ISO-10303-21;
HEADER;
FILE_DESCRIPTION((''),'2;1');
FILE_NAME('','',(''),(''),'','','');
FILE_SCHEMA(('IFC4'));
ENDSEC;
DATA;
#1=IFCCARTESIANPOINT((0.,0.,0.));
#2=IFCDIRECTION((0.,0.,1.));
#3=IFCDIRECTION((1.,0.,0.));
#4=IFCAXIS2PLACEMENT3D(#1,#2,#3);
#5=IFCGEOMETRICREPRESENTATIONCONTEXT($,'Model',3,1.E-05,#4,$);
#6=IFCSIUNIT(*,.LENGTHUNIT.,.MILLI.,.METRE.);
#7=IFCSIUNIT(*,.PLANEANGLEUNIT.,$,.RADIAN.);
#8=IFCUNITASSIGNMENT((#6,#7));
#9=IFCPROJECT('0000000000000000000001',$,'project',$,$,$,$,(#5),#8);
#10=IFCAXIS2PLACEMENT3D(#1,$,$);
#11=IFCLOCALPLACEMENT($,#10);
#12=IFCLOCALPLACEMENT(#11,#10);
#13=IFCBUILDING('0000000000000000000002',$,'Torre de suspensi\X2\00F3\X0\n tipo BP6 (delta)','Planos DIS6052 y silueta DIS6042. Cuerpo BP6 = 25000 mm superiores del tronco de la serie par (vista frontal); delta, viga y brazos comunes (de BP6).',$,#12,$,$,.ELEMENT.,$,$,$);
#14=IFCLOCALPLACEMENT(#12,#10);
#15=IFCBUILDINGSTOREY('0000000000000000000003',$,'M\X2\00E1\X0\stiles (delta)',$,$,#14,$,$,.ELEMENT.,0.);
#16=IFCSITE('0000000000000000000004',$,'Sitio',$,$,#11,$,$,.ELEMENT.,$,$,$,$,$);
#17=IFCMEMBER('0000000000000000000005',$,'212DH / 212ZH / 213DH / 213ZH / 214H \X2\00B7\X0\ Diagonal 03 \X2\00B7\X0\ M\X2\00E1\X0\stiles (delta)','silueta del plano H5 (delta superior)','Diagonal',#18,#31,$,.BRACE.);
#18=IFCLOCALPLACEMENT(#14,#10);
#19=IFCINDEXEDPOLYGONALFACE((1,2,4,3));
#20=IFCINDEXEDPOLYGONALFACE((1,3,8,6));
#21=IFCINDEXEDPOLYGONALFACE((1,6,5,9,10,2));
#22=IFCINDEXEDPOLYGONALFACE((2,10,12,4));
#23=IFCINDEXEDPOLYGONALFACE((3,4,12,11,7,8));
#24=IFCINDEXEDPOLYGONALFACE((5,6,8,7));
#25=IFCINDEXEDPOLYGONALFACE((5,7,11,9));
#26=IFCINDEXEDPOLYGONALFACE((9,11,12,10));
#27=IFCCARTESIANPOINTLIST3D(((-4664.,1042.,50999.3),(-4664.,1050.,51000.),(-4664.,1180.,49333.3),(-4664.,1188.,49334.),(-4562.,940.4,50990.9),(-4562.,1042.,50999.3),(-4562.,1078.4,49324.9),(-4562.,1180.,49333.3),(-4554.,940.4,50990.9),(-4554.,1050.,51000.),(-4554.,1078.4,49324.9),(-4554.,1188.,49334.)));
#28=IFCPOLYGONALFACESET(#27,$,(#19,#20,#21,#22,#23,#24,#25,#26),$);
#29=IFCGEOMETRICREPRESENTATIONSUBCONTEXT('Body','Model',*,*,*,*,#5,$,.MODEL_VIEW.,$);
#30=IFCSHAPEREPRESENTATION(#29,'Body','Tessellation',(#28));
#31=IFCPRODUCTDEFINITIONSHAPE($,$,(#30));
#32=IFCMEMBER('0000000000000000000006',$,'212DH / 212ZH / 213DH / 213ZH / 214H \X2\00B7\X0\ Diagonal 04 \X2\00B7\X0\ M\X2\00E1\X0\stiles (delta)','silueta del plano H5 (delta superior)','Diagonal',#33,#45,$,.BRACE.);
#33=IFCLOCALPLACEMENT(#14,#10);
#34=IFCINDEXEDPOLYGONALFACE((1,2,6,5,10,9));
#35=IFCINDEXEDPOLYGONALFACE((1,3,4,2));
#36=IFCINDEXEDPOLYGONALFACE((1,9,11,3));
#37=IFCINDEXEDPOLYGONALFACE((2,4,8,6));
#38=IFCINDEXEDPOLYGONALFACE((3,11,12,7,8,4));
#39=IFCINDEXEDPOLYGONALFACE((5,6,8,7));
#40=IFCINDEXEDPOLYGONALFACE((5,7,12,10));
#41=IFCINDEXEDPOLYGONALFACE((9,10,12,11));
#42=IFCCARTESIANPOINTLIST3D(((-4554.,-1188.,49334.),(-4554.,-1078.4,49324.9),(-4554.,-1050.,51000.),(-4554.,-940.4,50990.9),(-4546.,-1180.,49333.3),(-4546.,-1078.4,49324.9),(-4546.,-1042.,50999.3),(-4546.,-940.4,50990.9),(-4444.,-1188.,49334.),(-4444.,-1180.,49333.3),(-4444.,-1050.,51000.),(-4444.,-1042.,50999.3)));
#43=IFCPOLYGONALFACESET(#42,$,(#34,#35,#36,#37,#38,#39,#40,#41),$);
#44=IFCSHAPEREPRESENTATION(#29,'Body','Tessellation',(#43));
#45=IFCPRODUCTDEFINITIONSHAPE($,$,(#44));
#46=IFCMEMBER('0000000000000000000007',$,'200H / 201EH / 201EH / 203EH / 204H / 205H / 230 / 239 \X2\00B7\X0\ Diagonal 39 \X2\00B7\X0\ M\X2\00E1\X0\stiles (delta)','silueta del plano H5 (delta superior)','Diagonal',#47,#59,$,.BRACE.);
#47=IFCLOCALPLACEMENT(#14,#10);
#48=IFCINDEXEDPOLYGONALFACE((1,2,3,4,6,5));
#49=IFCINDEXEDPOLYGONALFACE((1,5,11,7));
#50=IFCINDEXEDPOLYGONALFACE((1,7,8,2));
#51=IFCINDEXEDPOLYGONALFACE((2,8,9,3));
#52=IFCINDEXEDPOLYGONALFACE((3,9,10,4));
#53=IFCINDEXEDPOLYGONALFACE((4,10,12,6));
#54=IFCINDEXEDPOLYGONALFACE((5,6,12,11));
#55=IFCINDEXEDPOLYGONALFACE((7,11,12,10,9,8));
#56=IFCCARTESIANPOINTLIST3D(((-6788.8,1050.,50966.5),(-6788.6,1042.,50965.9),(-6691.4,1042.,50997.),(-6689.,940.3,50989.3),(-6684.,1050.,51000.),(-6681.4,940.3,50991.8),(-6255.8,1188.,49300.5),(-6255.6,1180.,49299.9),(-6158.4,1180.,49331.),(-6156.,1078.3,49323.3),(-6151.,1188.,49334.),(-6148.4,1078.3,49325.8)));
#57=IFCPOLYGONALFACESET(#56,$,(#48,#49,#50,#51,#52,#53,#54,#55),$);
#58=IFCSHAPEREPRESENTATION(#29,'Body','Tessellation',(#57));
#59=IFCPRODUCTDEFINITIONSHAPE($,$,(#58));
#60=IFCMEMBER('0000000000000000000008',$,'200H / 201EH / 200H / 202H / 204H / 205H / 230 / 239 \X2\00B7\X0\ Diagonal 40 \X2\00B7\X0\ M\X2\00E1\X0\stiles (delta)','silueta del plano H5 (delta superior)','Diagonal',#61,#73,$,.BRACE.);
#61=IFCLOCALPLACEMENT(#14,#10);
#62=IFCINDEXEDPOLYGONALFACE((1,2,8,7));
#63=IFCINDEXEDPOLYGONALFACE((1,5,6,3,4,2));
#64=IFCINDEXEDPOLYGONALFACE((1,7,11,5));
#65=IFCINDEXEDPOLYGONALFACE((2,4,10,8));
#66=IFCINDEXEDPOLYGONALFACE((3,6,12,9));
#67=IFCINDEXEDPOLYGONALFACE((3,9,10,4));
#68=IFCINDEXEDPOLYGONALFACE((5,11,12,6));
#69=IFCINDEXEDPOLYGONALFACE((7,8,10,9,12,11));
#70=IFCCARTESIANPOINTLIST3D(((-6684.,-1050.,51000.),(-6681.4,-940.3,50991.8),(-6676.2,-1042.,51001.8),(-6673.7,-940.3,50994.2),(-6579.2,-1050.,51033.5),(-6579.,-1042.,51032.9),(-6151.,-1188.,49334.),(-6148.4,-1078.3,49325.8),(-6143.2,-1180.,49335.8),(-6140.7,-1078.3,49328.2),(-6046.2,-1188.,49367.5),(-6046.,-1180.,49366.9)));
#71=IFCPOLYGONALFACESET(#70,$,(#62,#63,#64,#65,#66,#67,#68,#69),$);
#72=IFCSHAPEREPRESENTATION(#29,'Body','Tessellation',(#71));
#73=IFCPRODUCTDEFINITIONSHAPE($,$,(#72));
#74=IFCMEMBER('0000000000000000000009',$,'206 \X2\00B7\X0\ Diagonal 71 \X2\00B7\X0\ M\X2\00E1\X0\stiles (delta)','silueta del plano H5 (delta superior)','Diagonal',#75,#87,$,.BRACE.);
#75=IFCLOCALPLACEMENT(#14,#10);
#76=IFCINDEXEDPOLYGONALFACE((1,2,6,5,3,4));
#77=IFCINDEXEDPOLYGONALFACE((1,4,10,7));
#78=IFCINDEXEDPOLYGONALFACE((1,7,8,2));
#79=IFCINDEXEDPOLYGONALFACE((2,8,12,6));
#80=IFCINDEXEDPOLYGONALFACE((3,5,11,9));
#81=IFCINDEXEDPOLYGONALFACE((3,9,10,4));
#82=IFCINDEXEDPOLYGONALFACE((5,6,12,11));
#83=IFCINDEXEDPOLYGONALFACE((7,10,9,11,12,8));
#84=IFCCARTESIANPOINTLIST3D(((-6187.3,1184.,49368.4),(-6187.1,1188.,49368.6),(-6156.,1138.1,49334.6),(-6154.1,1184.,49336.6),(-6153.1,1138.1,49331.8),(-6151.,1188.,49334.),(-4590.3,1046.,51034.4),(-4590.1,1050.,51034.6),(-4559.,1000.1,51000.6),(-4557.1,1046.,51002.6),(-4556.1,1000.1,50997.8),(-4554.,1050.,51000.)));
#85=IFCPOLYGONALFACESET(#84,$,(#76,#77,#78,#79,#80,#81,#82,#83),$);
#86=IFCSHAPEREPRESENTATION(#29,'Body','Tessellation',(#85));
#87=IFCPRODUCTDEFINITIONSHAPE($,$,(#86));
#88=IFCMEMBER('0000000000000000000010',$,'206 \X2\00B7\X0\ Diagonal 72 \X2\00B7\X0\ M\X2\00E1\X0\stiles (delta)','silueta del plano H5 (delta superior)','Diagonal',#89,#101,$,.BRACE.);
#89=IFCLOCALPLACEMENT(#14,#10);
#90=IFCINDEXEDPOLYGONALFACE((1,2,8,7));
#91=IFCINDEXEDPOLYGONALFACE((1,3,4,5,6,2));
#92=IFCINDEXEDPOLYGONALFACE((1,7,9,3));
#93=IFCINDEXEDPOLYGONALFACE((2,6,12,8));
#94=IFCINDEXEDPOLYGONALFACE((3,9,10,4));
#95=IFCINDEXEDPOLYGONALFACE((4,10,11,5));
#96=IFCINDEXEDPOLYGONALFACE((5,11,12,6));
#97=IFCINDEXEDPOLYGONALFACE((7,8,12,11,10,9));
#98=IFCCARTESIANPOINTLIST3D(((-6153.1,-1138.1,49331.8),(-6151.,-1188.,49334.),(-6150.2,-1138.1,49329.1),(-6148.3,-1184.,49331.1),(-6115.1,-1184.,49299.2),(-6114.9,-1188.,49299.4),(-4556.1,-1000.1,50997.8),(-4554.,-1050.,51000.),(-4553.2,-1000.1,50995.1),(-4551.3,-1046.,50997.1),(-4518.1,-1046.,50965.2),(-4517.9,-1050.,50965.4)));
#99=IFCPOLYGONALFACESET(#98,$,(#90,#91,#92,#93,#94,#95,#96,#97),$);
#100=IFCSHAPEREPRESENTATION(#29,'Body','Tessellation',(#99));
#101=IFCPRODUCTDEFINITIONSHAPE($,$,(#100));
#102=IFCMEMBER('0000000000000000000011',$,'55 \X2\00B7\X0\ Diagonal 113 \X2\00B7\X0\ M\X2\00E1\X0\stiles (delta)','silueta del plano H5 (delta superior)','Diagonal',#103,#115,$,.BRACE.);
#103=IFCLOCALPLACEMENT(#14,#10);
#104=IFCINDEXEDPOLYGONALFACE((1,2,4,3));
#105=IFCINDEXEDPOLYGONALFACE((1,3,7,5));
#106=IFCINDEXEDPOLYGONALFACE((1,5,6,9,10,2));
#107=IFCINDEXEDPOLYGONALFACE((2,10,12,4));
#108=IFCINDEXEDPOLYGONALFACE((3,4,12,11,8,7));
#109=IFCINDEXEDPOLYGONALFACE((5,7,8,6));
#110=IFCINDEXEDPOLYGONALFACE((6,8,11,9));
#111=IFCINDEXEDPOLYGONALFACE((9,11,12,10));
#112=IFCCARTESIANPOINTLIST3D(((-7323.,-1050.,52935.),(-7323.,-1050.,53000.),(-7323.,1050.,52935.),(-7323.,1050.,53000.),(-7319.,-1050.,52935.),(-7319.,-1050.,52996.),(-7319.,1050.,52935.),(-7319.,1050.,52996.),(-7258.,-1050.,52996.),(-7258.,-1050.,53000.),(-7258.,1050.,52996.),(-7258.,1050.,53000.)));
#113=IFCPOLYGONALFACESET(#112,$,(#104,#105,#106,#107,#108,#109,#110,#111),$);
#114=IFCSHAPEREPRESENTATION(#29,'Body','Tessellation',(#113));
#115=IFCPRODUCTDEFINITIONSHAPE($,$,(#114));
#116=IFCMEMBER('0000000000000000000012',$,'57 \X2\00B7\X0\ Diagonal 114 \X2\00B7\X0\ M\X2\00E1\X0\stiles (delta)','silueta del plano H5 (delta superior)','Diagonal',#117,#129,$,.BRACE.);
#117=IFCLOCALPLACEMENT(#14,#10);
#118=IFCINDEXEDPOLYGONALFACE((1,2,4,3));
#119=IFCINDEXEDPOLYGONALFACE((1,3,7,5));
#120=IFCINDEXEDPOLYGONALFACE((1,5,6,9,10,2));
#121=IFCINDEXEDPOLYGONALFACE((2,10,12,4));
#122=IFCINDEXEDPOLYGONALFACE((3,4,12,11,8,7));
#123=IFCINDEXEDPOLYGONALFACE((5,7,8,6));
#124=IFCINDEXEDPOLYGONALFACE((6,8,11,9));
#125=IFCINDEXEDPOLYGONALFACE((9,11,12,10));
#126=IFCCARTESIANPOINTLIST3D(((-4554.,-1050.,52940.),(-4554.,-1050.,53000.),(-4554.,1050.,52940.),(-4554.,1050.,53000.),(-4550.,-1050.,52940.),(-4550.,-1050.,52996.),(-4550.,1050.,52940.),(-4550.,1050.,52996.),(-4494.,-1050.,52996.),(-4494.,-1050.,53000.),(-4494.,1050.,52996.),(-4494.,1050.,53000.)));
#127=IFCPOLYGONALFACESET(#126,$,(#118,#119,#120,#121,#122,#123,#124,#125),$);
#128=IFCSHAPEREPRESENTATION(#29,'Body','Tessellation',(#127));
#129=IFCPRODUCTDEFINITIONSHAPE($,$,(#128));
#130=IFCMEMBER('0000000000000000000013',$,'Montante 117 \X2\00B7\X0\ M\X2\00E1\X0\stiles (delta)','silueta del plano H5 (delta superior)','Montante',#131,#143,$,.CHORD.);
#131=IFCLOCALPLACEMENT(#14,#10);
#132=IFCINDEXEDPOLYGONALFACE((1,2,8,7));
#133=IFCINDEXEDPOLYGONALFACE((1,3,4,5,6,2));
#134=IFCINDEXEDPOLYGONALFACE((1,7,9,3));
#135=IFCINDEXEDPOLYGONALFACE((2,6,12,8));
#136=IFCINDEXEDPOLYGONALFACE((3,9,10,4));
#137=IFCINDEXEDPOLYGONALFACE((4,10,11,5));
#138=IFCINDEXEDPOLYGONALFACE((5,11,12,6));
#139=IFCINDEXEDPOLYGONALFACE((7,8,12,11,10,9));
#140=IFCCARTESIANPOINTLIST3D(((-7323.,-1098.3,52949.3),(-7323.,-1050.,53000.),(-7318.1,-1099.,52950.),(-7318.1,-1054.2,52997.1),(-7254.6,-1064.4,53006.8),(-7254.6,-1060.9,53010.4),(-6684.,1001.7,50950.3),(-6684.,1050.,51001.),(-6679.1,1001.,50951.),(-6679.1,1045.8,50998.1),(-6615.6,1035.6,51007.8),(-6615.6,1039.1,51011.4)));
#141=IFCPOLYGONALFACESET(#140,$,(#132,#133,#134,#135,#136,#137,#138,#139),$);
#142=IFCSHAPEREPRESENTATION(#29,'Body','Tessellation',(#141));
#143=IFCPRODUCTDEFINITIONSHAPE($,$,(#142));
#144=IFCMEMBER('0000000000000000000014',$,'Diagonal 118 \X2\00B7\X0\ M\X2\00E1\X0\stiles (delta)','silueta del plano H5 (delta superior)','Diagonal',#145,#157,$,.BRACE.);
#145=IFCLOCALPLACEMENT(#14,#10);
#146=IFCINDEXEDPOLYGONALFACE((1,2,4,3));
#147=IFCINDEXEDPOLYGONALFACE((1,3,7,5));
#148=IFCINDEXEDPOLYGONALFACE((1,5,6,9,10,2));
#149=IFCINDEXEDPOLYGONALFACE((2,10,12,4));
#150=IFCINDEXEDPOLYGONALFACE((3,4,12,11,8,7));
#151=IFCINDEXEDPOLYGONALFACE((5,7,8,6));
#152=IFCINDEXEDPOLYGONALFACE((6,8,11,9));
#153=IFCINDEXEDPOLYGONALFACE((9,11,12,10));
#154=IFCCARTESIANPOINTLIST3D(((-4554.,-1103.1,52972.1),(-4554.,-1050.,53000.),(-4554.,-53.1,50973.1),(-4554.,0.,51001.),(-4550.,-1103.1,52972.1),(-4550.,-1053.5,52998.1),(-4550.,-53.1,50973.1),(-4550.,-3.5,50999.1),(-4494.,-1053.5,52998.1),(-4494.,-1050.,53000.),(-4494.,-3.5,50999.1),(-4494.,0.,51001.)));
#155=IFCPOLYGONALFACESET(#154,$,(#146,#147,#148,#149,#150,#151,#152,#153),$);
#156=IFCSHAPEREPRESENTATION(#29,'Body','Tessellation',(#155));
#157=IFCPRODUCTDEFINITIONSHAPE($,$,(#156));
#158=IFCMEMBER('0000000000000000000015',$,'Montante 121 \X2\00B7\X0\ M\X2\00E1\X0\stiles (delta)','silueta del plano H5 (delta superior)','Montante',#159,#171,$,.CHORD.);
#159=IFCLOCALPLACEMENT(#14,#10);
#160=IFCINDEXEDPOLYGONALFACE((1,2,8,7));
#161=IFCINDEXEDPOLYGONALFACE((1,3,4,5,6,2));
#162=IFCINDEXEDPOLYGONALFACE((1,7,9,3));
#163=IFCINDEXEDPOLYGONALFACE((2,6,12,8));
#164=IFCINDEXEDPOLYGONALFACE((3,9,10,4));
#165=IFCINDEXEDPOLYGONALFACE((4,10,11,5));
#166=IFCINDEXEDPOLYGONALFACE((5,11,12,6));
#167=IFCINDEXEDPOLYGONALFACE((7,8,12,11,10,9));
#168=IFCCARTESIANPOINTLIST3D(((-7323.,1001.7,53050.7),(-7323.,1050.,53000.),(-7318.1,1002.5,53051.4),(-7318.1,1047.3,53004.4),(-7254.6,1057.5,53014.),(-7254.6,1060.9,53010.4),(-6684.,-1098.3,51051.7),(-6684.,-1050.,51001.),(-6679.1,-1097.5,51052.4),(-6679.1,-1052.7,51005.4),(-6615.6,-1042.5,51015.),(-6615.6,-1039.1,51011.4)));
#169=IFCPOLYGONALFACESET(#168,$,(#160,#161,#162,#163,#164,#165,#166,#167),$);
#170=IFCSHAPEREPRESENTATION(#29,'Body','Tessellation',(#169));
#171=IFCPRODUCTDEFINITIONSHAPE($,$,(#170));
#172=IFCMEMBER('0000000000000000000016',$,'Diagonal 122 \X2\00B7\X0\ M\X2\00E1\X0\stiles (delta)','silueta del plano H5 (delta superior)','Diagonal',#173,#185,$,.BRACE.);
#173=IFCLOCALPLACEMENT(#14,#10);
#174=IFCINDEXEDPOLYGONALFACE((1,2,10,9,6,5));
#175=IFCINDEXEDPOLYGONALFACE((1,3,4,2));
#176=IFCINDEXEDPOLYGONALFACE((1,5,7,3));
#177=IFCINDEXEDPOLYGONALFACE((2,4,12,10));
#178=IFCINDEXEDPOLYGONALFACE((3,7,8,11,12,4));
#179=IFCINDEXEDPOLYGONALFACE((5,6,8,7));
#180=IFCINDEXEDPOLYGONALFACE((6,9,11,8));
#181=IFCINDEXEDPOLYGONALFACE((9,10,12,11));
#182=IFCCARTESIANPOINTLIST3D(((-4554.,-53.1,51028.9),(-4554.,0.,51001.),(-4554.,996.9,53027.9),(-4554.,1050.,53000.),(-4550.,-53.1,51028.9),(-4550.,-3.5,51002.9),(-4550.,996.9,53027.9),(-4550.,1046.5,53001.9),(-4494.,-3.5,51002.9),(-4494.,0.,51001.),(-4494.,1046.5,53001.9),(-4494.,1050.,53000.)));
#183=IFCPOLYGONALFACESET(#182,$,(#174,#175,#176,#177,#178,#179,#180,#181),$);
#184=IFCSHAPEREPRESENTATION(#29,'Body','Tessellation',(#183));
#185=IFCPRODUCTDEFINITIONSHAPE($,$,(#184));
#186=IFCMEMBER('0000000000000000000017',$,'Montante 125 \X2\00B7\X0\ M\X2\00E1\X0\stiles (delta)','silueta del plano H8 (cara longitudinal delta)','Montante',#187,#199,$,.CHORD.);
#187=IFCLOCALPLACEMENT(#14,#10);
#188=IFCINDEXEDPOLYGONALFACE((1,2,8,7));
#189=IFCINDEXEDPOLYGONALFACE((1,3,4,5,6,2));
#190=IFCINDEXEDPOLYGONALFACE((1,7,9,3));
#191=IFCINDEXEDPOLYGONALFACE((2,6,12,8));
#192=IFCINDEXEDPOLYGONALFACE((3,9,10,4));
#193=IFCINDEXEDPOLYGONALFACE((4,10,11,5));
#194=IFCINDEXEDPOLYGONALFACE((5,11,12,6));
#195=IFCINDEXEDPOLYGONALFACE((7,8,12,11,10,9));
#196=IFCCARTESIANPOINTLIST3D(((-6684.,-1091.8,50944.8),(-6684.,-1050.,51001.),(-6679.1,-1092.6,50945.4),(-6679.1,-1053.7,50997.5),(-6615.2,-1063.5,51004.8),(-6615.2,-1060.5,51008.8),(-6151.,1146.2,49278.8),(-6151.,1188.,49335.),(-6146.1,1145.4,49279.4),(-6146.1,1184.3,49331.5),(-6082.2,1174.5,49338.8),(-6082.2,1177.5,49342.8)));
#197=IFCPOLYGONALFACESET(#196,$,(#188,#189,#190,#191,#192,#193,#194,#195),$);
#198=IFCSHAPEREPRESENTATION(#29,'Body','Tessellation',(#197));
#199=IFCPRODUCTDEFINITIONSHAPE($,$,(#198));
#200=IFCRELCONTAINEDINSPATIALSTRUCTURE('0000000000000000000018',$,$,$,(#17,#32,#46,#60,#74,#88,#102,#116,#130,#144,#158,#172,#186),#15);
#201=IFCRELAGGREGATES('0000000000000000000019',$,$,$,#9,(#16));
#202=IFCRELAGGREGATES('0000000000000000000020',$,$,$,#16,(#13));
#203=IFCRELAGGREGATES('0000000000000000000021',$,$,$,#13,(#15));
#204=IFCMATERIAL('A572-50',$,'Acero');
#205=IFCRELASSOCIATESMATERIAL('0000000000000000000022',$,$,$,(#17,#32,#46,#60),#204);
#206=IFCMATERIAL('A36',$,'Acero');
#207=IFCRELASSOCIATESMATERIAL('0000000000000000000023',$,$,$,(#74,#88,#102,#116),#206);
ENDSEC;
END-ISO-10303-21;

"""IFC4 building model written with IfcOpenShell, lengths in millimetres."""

from ifc_helpers import new_model, si_unit, frame, frame_2d, origin, origin_with_axes, place, context, subcontext, project, spatial, l_section, extrude, material, element, save


model = new_model("IFC4")

# Units and contexts
model_context = context("Model", 3, precision=1e-05, world=origin_with_axes())
body_context = subcontext(model_context, "Body", "Model", "MODEL_VIEW")
ifc_project = project(units=[si_unit("LENGTHUNIT", "METRE", prefix="MILLI"), si_unit("PLANEANGLEUNIT", "RADIAN")], contexts=[model_context])

# Site, building, storey
site_placement = place(None, origin())
site = spatial("IfcSite", under=ifc_project, at=site_placement, Name="Sitio", CompositionType="ELEMENT")
building_placement = place(site_placement, origin())
building = spatial("IfcBuilding", under=site, at=building_placement, Name="Torre de suspensión tipo BP6 (delta)", Description="Planos DIS6052 y silueta DIS6042. Cuerpo BP6 = 25000 mm superiores del tronco de la serie par (vista frontal); delta, viga y brazos comunes (de BP6).", CompositionType="ELEMENT")
storey_placement = place(building_placement, origin())
storey = spatial("IfcBuildingStorey", under=building, at=storey_placement, Name="Mástiles (delta)", CompositionType="ELEMENT", Elevation=0.0)

# Members
ifc_material_1 = material(Name="A572-50", Category="Acero")
for number, where, z_axis, x_axis, name in (
    (1, (-4554.0, 1050.0, 51000.0), (0.0, 0.08255, -0.996587), (0.0, -0.996587, -0.08255), "212DH / 212ZH / 213DH / 213ZH / 214H · Diagonal 03 · Mástiles (delta)"),
    (2, (-4554.0, -1050.0, 51000.0), (0.0, -0.08255, -0.996587), (0.0, 0.996587, -0.08255), "212DH / 212ZH / 213DH / 213ZH / 214H · Diagonal 04 · Mástiles (delta)"),
):
    element("IfcMember", number, at=place(storey_placement, frame(where, z_axis=z_axis, x_axis=x_axis)), inside=storey, material=ifc_material_1, Name=name, Description="silueta del plano H5 (delta superior)", ObjectType="Diagonal", PredefinedType="BRACE", context=body_context, shape_type="SweptSolid", body=[
        extrude(l_section(Depth=110.0, Width=110.0, Thickness=8.0, at=frame_2d((55.0, 55.0))), None, (0.0, 0.0, 1.0), 1671.7),
    ])
for number, where, z_axis, x_axis, name in (
    (3, (-6684.0, 1050.0, 51000.0), (0.30377, 0.07865, -0.949494), (0.023966, -0.996902, -0.074909), "200H / 201EH / 201EH / 203EH / 204H / 205H / 230 / 239 · Diagonal 39 · Mástiles (delta)"),
    (4, (-6684.0, -1050.0, 51000.0), (0.30377, -0.07865, -0.949494), (0.023966, 0.996902, -0.074909), "200H / 201EH / 200H / 202H / 204H / 205H / 230 / 239 · Diagonal 40 · Mástiles (delta)"),
):
    element("IfcMember", number, at=place(storey_placement, frame(where, z_axis=z_axis, x_axis=x_axis)), inside=storey, material=ifc_material_1, Name=name, Description="silueta del plano H5 (delta superior)", ObjectType="Diagonal", PredefinedType="BRACE", context=body_context, shape_type="SweptSolid", body=[
        extrude(l_section(Depth=110.0, Width=110.0, Thickness=8.0, at=frame_2d((55.0, 55.0))), None, (0.0, 0.0, 1.0), 1754.6),
    ])
ifc_material_2 = material(Name="A36", Category="Acero")
for number, where, z_axis, x_axis, name in (
    (5, (-4554.0, 1050.0, 51000.0), (-0.690766, 0.05969, -0.720611), (-0.041306, -0.998217, -0.04309), "206 · Diagonal 71 · Mástiles (delta)"),
    (6, (-4554.0, -1050.0, 51000.0), (-0.690766, -0.05969, -0.720611), (-0.041306, 0.998217, -0.04309), "206 · Diagonal 72 · Mástiles (delta)"),
):
    element("IfcMember", number, at=place(storey_placement, frame(where, z_axis=z_axis, x_axis=x_axis)), inside=storey, material=ifc_material_2, Name=name, Description="silueta del plano H5 (delta superior)", ObjectType="Diagonal", PredefinedType="BRACE", context=body_context, shape_type="SweptSolid", body=[
        extrude(l_section(Depth=50.0, Width=50.0, Thickness=4.0, at=frame_2d((25.0, 25.0))), None, (0.0, 0.0, 1.0), 2311.9),
    ])
member_1_placement = place(storey_placement, frame((-7323.0, -1050.0, 53000.0), z_axis=(0.0, 1.0, 0.0), x_axis=(1.0, 0.0, 0.0)))
element("IfcMember", 7, at=member_1_placement, inside=storey, material=ifc_material_2, Name="55 · Diagonal 113 · Mástiles (delta)", Description="silueta del plano H5 (delta superior)", ObjectType="Diagonal", PredefinedType="BRACE", context=body_context, shape_type="SweptSolid", body=[
    extrude(l_section(Depth=65.0, Width=65.0, Thickness=4.0, at=frame_2d((32.5, 32.5))), None, (0.0, 0.0, 1.0), 2100.0),
])
member_2_placement = place(storey_placement, frame((-4554.0, -1050.0, 53000.0), z_axis=(0.0, 1.0, 0.0), x_axis=(1.0, 0.0, 0.0)))
element("IfcMember", 8, at=member_2_placement, inside=storey, material=ifc_material_2, Name="57 · Diagonal 114 · Mástiles (delta)", Description="silueta del plano H5 (delta superior)", ObjectType="Diagonal", PredefinedType="BRACE", context=body_context, shape_type="SweptSolid", body=[
    extrude(l_section(Depth=60.0, Width=60.0, Thickness=4.0, at=frame_2d((30.0, 30.0))), None, (0.0, 0.0, 1.0), 2100.0),
])
member_3_placement = place(storey_placement, frame((-7323.0, -1050.0, 53000.0), z_axis=(0.215232, 0.707334, -0.673315), x_axis=(0.976563, -0.155895, 0.148397)))
element("IfcMember", 9, at=member_3_placement, inside=storey, Name="Montante 117 · Mástiles (delta)", Description="silueta del plano H5 (delta superior)", ObjectType="Montante", PredefinedType="CHORD", context=body_context, shape_type="SweptSolid", body=[
    extrude(l_section(Depth=70.0, Width=70.0, Thickness=5.0, at=frame_2d((35.0, 35.0))), None, (0.0, 0.0, 1.0), 2968.9),
])
member_4_placement = place(storey_placement, frame((-4554.0, -1050.0, 53000.0), z_axis=(0.0, 0.465016, -0.885302), x_axis=(1.0, 0.0, 0.0)))
element("IfcMember", 10, at=member_4_placement, inside=storey, Name="Diagonal 118 · Mástiles (delta)", Description="silueta del plano H5 (delta superior)", ObjectType="Diagonal", PredefinedType="BRACE", context=body_context, shape_type="SweptSolid", body=[
    extrude(l_section(Depth=60.0, Width=60.0, Thickness=4.0, at=frame_2d((30.0, 30.0))), None, (0.0, 0.0, 1.0), 2258.0),
])
member_5_placement = place(storey_placement, frame((-7323.0, 1050.0, 53000.0), z_axis=(0.215232, -0.707334, -0.673315), x_axis=(0.976563, 0.155895, 0.148397)))
element("IfcMember", 11, at=member_5_placement, inside=storey, Name="Montante 121 · Mástiles (delta)", Description="silueta del plano H5 (delta superior)", ObjectType="Montante", PredefinedType="CHORD", context=body_context, shape_type="SweptSolid", body=[
    extrude(l_section(Depth=70.0, Width=70.0, Thickness=5.0, at=frame_2d((35.0, 35.0))), None, (0.0, 0.0, 1.0), 2968.9),
])
member_6_placement = place(storey_placement, frame((-4554.0, 1050.0, 53000.0), z_axis=(0.0, -0.465016, -0.885302), x_axis=(1.0, 0.0, 0.0)))
element("IfcMember", 12, at=member_6_placement, inside=storey, Name="Diagonal 122 · Mástiles (delta)", Description="silueta del plano H5 (delta superior)", ObjectType="Diagonal", PredefinedType="BRACE", context=body_context, shape_type="SweptSolid", body=[
    extrude(l_section(Depth=60.0, Width=60.0, Thickness=4.0, at=frame_2d((30.0, 30.0))), None, (0.0, 0.0, 1.0), 2258.0),
])
member_7_placement = place(storey_placement, frame((-6684.0, -1050.0, 51001.0), z_axis=(0.187645, 0.787897, -0.586522), x_axis=(0.982237, -0.150518, 0.112048)))
element("IfcMember", 13, at=member_7_placement, inside=storey, Name="Montante 125 · Mástiles (delta)", Description="silueta del plano H8 (cara longitudinal delta)", ObjectType="Montante", PredefinedType="CHORD", context=body_context, shape_type="SweptSolid", body=[
    extrude(l_section(Depth=70.0, Width=70.0, Thickness=5.0, at=frame_2d((35.0, 35.0))), None, (0.0, 0.0, 1.0), 2840.5),
])

save(model, "model.ifc")
